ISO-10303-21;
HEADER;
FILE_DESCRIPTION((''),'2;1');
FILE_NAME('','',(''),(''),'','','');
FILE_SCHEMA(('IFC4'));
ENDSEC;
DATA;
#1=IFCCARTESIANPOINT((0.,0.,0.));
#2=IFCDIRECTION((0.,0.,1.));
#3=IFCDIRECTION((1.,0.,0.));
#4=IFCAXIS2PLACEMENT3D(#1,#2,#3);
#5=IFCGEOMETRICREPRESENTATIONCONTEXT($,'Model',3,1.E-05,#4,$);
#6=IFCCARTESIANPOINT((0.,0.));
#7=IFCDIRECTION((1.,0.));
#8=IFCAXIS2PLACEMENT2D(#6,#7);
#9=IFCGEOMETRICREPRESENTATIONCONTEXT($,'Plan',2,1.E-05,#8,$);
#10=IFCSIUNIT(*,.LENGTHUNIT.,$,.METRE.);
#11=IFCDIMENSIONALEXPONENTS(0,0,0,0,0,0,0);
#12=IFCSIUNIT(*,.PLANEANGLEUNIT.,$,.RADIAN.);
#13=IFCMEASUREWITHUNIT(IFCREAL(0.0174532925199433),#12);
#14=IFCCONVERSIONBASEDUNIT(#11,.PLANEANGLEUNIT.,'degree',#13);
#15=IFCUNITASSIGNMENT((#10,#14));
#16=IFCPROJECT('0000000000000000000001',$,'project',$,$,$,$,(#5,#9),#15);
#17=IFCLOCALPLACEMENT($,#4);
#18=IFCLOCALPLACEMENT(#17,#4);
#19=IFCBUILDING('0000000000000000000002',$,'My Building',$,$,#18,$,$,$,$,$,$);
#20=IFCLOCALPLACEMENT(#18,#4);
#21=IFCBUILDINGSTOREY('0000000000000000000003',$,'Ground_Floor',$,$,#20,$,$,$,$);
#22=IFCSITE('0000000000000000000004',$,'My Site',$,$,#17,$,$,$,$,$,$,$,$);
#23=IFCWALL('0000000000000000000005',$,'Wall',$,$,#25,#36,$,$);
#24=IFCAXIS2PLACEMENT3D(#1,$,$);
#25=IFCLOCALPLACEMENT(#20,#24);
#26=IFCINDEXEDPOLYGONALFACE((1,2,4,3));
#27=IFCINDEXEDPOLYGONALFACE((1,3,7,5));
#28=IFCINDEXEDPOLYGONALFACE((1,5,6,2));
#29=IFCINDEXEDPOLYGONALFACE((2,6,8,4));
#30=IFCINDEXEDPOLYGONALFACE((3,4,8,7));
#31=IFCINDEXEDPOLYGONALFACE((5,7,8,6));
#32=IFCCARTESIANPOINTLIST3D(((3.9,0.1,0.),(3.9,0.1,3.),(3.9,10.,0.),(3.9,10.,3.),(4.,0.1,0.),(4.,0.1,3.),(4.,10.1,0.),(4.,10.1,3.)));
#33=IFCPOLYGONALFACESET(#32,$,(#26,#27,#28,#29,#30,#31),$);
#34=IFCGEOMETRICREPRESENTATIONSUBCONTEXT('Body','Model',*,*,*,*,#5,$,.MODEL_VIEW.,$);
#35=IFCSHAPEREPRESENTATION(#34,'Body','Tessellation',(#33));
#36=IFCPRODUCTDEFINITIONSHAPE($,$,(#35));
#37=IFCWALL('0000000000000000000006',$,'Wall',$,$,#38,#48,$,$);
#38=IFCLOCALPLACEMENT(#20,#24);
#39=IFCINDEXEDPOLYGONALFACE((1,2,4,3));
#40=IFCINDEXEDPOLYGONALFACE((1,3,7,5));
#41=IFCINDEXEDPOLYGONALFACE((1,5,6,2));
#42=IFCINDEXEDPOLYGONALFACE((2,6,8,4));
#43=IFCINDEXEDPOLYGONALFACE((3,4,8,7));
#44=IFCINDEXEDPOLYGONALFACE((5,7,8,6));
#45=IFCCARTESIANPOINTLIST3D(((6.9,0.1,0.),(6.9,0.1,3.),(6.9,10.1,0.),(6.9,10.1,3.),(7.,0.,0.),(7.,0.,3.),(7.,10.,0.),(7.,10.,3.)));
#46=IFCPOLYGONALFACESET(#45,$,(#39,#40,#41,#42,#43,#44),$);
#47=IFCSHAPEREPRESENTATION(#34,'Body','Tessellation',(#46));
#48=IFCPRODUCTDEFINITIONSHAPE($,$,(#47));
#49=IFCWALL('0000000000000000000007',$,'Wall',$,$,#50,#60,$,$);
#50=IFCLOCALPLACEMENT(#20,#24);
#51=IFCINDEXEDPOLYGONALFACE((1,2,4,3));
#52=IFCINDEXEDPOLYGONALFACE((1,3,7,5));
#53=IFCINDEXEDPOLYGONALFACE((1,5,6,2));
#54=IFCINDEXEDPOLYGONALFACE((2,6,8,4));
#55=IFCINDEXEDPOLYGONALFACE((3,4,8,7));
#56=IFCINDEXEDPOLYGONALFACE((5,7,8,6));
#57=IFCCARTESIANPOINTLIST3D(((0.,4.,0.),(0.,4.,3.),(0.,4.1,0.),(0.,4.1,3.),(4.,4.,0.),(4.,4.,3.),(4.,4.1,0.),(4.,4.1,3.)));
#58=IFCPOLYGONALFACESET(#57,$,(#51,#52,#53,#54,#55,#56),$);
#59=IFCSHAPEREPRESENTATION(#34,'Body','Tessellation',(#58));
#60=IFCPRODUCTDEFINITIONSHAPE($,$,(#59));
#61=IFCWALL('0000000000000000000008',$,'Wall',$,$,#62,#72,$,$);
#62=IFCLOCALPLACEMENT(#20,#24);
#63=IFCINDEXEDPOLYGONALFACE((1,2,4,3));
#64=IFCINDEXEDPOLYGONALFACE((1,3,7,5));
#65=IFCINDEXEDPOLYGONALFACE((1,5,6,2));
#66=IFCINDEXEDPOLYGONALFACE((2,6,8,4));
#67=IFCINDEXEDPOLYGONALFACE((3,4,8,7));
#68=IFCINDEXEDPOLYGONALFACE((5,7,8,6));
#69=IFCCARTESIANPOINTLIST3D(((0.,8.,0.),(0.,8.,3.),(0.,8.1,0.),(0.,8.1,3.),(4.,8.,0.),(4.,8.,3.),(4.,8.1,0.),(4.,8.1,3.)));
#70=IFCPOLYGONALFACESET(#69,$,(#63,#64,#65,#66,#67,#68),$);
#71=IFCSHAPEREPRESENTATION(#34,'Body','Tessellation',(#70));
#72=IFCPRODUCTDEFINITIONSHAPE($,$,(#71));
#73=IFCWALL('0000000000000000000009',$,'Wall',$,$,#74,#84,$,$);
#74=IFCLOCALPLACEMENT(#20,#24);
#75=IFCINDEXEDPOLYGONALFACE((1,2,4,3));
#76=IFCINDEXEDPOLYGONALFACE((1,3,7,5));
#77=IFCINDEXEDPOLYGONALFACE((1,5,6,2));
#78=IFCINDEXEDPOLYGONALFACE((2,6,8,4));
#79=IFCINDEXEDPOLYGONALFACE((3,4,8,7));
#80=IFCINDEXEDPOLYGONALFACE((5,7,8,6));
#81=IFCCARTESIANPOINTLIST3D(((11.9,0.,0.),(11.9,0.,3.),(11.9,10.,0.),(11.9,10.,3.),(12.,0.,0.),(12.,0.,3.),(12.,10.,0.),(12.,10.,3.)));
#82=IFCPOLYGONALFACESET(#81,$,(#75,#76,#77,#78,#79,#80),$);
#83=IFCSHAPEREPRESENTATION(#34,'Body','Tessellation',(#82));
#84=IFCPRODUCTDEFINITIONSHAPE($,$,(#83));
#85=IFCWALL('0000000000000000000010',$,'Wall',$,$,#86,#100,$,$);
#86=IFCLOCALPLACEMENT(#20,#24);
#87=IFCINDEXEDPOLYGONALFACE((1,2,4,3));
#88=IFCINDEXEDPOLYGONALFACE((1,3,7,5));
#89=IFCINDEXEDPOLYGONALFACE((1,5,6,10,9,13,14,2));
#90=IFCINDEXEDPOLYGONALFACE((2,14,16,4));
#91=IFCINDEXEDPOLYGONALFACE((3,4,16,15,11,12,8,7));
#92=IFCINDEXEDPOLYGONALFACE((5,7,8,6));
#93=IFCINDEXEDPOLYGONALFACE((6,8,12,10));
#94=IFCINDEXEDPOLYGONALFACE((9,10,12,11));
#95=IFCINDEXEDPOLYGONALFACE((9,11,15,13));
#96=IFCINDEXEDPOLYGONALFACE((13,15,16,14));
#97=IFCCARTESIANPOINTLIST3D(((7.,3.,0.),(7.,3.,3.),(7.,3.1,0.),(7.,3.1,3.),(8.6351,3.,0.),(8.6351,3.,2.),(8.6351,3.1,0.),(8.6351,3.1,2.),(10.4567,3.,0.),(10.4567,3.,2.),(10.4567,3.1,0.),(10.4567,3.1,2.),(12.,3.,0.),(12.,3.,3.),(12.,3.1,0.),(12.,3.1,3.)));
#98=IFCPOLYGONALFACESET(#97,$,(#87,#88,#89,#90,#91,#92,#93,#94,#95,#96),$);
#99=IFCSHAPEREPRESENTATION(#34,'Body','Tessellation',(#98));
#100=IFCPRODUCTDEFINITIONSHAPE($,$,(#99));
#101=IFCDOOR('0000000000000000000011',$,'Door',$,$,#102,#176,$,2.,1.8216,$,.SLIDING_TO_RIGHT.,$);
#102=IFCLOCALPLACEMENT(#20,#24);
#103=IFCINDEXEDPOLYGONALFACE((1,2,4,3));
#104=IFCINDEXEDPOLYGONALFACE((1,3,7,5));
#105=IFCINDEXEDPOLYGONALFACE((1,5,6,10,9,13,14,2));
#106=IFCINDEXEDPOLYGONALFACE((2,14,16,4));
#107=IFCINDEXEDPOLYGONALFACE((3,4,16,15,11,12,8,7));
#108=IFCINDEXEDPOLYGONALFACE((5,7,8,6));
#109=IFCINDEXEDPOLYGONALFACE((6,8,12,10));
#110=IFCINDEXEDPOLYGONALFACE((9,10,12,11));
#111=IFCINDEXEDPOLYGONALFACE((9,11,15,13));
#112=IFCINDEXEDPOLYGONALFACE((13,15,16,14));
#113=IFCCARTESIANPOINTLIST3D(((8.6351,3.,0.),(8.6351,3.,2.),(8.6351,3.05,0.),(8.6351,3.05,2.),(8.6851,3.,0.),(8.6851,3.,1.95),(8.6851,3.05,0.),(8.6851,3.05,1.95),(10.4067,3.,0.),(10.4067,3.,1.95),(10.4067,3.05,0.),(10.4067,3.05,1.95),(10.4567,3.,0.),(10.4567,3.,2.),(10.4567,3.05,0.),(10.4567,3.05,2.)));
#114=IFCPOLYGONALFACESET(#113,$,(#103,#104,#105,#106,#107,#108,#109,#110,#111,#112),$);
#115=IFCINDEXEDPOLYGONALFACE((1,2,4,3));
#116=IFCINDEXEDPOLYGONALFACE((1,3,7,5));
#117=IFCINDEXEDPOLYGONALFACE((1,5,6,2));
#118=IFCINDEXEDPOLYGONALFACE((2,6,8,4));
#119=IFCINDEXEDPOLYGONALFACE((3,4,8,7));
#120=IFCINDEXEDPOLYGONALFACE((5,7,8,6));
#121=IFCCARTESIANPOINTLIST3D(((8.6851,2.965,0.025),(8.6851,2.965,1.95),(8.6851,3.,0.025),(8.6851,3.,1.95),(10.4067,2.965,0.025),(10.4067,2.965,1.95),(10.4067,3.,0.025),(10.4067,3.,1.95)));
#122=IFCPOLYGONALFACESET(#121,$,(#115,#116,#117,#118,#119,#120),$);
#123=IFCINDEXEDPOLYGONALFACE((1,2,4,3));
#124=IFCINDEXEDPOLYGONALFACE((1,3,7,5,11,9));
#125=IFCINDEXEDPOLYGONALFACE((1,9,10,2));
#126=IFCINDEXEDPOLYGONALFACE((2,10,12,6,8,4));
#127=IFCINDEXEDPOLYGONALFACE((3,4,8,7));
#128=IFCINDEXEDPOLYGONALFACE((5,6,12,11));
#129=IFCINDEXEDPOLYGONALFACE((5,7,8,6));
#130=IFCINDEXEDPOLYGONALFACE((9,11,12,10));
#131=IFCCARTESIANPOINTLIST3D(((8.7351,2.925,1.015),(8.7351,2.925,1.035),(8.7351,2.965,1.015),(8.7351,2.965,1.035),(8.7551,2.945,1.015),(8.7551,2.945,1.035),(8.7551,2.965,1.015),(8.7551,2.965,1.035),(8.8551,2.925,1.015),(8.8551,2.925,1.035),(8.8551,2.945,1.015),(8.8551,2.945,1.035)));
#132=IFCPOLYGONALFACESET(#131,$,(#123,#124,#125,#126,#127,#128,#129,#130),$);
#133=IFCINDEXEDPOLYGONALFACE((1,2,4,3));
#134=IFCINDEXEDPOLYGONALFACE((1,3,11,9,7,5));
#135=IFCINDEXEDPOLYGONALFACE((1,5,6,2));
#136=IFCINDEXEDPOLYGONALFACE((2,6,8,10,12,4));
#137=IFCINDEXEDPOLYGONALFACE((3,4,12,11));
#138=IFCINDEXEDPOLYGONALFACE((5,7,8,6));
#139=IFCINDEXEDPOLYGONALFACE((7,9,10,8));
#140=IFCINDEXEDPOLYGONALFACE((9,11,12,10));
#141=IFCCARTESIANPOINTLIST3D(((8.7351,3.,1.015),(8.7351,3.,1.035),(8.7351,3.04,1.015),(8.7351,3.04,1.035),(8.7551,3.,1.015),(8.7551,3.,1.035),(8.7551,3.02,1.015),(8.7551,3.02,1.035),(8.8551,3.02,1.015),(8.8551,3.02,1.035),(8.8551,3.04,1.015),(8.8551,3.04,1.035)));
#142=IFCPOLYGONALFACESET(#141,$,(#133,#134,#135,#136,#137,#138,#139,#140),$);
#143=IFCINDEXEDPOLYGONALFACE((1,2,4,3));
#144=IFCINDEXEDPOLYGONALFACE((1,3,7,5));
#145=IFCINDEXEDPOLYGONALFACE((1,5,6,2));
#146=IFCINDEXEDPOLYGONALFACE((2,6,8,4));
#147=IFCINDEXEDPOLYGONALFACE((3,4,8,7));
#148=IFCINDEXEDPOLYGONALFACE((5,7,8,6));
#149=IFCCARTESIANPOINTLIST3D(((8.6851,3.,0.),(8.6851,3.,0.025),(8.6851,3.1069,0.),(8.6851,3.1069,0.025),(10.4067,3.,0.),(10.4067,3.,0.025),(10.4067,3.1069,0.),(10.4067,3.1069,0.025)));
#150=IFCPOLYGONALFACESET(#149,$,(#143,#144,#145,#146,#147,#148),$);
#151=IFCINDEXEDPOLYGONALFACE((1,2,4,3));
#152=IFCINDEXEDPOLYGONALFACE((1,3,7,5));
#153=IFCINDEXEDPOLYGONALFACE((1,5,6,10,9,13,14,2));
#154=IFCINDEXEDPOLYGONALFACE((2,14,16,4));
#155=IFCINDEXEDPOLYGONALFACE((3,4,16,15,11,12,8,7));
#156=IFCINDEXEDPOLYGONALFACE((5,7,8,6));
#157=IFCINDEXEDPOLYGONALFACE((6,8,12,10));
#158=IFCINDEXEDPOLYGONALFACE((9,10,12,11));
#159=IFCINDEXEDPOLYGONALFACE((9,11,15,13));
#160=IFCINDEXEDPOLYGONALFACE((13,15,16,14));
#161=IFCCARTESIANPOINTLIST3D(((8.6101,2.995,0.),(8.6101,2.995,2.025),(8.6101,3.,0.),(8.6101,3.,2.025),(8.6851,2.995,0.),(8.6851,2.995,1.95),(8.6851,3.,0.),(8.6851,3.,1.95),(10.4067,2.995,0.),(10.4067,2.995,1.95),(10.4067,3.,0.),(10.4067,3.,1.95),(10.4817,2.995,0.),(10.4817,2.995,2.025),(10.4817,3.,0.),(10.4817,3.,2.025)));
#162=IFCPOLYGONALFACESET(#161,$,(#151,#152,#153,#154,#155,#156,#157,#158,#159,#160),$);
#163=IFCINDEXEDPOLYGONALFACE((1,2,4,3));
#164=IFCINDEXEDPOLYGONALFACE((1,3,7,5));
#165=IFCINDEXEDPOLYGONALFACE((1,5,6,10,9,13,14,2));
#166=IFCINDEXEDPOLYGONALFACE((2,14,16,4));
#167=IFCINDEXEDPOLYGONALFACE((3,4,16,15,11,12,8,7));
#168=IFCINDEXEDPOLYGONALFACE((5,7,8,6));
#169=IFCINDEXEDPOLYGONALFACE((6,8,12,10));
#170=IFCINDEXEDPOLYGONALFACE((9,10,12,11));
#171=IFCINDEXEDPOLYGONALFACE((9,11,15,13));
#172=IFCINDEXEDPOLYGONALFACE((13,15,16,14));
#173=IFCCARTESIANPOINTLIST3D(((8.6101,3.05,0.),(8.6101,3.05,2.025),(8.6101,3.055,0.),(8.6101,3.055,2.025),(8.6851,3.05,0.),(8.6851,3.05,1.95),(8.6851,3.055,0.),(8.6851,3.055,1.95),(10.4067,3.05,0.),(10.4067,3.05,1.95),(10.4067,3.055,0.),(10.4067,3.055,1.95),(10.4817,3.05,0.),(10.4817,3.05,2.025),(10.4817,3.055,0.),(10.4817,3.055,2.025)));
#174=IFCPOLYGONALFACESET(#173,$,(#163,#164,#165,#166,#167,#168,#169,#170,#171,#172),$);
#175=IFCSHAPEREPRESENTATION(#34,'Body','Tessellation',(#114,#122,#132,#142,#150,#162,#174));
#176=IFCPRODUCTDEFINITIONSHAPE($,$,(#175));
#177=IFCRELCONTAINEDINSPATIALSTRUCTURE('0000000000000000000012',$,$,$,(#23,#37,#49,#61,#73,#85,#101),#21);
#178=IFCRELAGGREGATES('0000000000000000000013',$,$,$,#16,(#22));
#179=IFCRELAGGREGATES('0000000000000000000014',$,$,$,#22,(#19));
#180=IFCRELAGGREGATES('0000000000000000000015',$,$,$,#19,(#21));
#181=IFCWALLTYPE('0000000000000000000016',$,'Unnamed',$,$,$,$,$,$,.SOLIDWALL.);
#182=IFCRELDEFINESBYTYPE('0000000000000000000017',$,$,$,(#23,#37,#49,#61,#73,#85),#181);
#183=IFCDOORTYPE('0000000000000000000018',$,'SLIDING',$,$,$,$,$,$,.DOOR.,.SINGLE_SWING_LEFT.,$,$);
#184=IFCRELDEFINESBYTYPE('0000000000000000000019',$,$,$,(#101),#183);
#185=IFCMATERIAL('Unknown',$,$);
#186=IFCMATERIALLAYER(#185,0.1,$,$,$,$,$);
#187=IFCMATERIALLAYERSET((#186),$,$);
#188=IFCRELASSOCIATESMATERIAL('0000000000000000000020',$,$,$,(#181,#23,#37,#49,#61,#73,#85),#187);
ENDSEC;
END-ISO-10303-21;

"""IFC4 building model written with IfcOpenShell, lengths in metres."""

from ifc_helpers import new_model, entity, si_unit, converted_unit, frame, origin_with_axes, origin_2d_with_axis, place, context, subcontext, project, spatial, line, indexed_curve, outline, extrude, shape, source, transform, mapped, material, layer, layer_set, layer_usage, type_object, type_shapes, element, fill, save


model = new_model("IFC4")

# Units and contexts
model_context = context("Model", 3, precision=1e-05, world=origin_with_axes())
plan_context = context("Plan", 2, precision=1e-05, world=origin_2d_with_axis())
body_context_1 = subcontext(model_context, "Body", "Model", "MODEL_VIEW")
body_context_2 = subcontext(plan_context, "Body", "Plan", "PLAN_VIEW")
ifc_project = project(units=[si_unit("LENGTHUNIT", "METRE"), converted_unit("PLANEANGLEUNIT", "degree", entity("IfcReal", 0.0174532925199433), si_unit("PLANEANGLEUNIT", "RADIAN"), dimensions=[0, 0, 0, 0, 0, 0, 0])], contexts=[model_context, plan_context])

# Site, building, storey
site_placement = place(None, origin_with_axes())
site = spatial("IfcSite", under=ifc_project, at=site_placement, Name="My Site")
building_placement = place(site_placement, origin_with_axes())
building = spatial("IfcBuilding", under=site, at=building_placement, Name="My Building")
storey_placement = place(building_placement, origin_with_axes())
storey = spatial("IfcBuildingStorey", under=building, at=storey_placement, Name="Ground_Floor")

# Walls
ifc_material = material(Name="Unknown")
ifc_layer = layer(ifc_material, 0.1)
ifc_layer_set = layer_set([ifc_layer])
ifc_layer_usage_1 = layer_usage(ifc_layer_set, "AXIS2", "POSITIVE", 0.0)
wall_type = type_object("IfcWallType", Name="Unnamed", PredefinedType="SOLIDWALL", material=ifc_layer_set)
wall_1_placement = place(storey_placement, frame((4.0, 0.0, 0.0), z_axis=(0.0, 0.0, 1.0), x_axis=(0.0, 1.0, 0.0)))
element("IfcWall", 1, at=wall_1_placement, inside=storey, type_object=wall_type, material=ifc_layer_usage_1, Name="Wall", context=body_context_1, shape_type="SweptSolid", body=[
    extrude(outline(indexed_curve([(0.1, 0.0), (0.1, 0.1), (10.0, 0.1), (10.1, 0.0)], segments=[line(1, 2, 3, 4, 1)])), origin_with_axes(), (0.0, 0.0, 1.0), 3.0),
])
ifc_layer_usage_2 = layer_usage(ifc_layer_set, "AXIS2", "POSITIVE", 0.0)
wall_2_placement = place(storey_placement, frame((7.0, 0.0, 0.0), z_axis=(0.0, 0.0, 1.0), x_axis=(0.0, 1.0, 0.0)))
element("IfcWall", 2, at=wall_2_placement, inside=storey, type_object=wall_type, material=ifc_layer_usage_2, Name="Wall", context=body_context_1, shape_type="SweptSolid", body=[
    extrude(outline(indexed_curve([(0.0, 0.0), (0.1, 0.1), (10.1, 0.1), (10.0, 0.0)], segments=[line(1, 2, 3, 4, 1)])), origin_with_axes(), (0.0, 0.0, 1.0), 3.0),
])
ifc_layer_usage_3 = layer_usage(ifc_layer_set, "AXIS2", "POSITIVE", 0.0)
wall_3_placement = place(storey_placement, frame((0.0, 4.0, 0.0), z_axis=(0.0, 0.0, 1.0), x_axis=(1.0, 0.0, 0.0)))
element("IfcWall", 3, at=wall_3_placement, inside=storey, type_object=wall_type, material=ifc_layer_usage_3, Name="Wall", context=body_context_1, shape_type="SweptSolid", body=[
    extrude(outline(indexed_curve([(0.0, 0.0), (0.0, 0.1), (4.0, 0.1), (4.0, 0.0)], segments=[line(1, 2, 3, 4, 1)])), origin_with_axes(), (0.0, 0.0, 1.0), 3.0),
])
ifc_layer_usage_4 = layer_usage(ifc_layer_set, "AXIS2", "POSITIVE", 0.0)
wall_4_placement = place(storey_placement, frame((0.0, 8.0, 0.0), z_axis=(0.0, 0.0, 1.0), x_axis=(1.0, 0.0, 0.0)))
element("IfcWall", 4, at=wall_4_placement, inside=storey, type_object=wall_type, material=ifc_layer_usage_4, Name="Wall", context=body_context_1, shape_type="SweptSolid", body=[
    extrude(outline(indexed_curve([(0.0, 0.0), (0.0, 0.1), (4.0, 0.1), (4.0, 0.0)], segments=[line(1, 2, 3, 4, 1)])), origin_with_axes(), (0.0, 0.0, 1.0), 3.0),
])
ifc_layer_usage_5 = layer_usage(ifc_layer_set, "AXIS2", "POSITIVE", 0.0)
wall_5_placement = place(storey_placement, frame((12.0, 0.0, 0.0), z_axis=(0.0, 0.0, 1.0), x_axis=(0.0, 1.0, 0.0)))
element("IfcWall", 5, at=wall_5_placement, inside=storey, type_object=wall_type, material=ifc_layer_usage_5, Name="Wall", context=body_context_1, shape_type="SweptSolid", body=[
    extrude(outline(indexed_curve([(0.0, 0.0), (0.0, 0.1), (10.0, 0.1), (10.0, 0.0)], segments=[line(1, 2, 3, 4, 1)])), origin_with_axes(), (0.0, 0.0, 1.0), 3.0),
])

# Wall, opening, door
ifc_layer_usage_6 = layer_usage(ifc_layer_set, "AXIS2", "POSITIVE", 0.0)
wall_6_placement = place(storey_placement, frame((7.0, 3.0, 0.0), z_axis=(0.0, 0.0, 1.0), x_axis=(1.0, 0.0, 0.0)))
wall_6 = element("IfcWall", 6, at=wall_6_placement, inside=storey, type_object=wall_type, material=ifc_layer_usage_6, Name="Wall", context=body_context_1, shape_type="SweptSolid", body=[
    extrude(outline(indexed_curve([(0.0, 0.0), (0.0, 0.1), (5.0, 0.1), (5.0, 0.0)], segments=[line(1, 2, 3, 4, 1)])), origin_with_axes(), (0.0, 0.0, 1.0), 3.0),
])
shared_shape_1 = source(origin_with_axes(), body_context_1, "Body", "SweptSolid", [
    extrude(outline(indexed_curve([(0.0, 0.0), (1.8216, 0.0), (1.8216, 2.0), (0.0, 2.0)], segments=[line(1, 2, 3, 4, 1)])), frame((0.0, -0.6, 0.0), z_axis=(0.0, -1.0, 0.0), x_axis=(1.0, 0.0, 0.0)), (0.0, 0.0, -1.0), 1.2),
])
opening_1_placement = place(wall_6_placement, frame((1.6351, 0.0, 0.0), z_axis=(0.0, 0.0, 1.0), x_axis=(1.0, 0.0, 0.0)))
opening_1 = element("IfcOpeningElement", 7, at=opening_1_placement, cuts=wall_6, PredefinedType="OPENING", context=body_context_1, shape_type="MappedRepresentation", body=[
    mapped(shared_shape_1, transform((0.0, 0.0, 0.0), x_axis=(1.0, 0.0, 0.0), y_axis=(0.0, 1.0, 0.0), z_axis=(0.0, 0.0, 1.0), scale=1.0)),
])
door_type_1 = type_object("IfcDoorType", Name="SLIDING", OperationType="SINGLE_SWING_LEFT", PredefinedType="DOOR")
shared_shape_2 = source(origin_with_axes(), body_context_1, "Body", "SweptSolid", [
    extrude(outline(indexed_curve([(0.0, 0.0), (0.0, 2.0), (1.8216, 2.0), (1.8216, 0.0), (1.7716, 0.0), (1.7716, 1.95), (0.05, 1.95), (0.05, 0.0)], segments=[line(1, 2, 3, 4, 5, 6, 7, 8, 1)])), frame((0.0, 0.0, 0.0), z_axis=(0.0, -1.0, 0.0), x_axis=(1.0, 0.0, 0.0)), (0.0, 0.0, -1.0), 0.05),
    extrude(outline(indexed_curve([(0.0, 0.0), (1.7216, 0.0), (1.7216, 0.035), (0.0, 0.035)], segments=[line(1, 2, 3, 4, 1)])), frame((0.05, -0.035, 0.025), z_axis=(0.0, 0.0, 1.0), x_axis=(1.0, 0.0, 0.0)), (0.0, 0.0, 1.0), 1.925),
    extrude(outline(indexed_curve([(0.0, 0.0), (0.0, -0.04), (0.12, -0.04), (0.12, -0.02), (0.02, -0.02), (0.02, 0.0)], segments=[line(1, 2, 3, 4, 5, 6, 1)])), frame((0.1, -0.035, 1.015), z_axis=(0.0, 0.0, 1.0), x_axis=(1.0, 0.0, 0.0)), (0.0, 0.0, 1.0), 0.02),
    extrude(outline(indexed_curve([(0.0, 0.0), (0.0, 0.04), (0.12, 0.04), (0.12, 0.02), (0.02, 0.02), (0.02, 0.0)], segments=[line(1, 2, 3, 4, 5, 6, 1)])), frame((0.1, 0.0, 1.015), z_axis=(0.0, 0.0, 1.0), x_axis=(1.0, 0.0, 0.0)), (0.0, 0.0, 1.0), 0.02),
    extrude(outline(indexed_curve([(0.0, 0.0), (1.7216, 0.0), (1.7216, 0.1069), (0.0, 0.1069)], segments=[line(1, 2, 3, 4, 1)])), frame((0.05, 0.0, 0.0), z_axis=(0.0, 0.0, 1.0), x_axis=(1.0, 0.0, 0.0)), (0.0, 0.0, 1.0), 0.025),
    extrude(outline(indexed_curve([(0.0, 0.0), (0.0, 2.025), (1.8716, 2.025), (1.8716, 0.0), (1.7966, 0.0), (1.7966, 1.95), (0.075, 1.95), (0.075, 0.0)], segments=[line(1, 2, 3, 4, 5, 6, 7, 8, 1)])), frame((-0.025, -0.005, 0.0), z_axis=(0.0, -1.0, 0.0), x_axis=(1.0, 0.0, 0.0)), (0.0, 0.0, -1.0), 0.005),
    extrude(outline(indexed_curve([(0.0, 0.0), (0.0, 2.025), (1.8716, 2.025), (1.8716, 0.0), (1.7966, 0.0), (1.7966, 1.95), (0.075, 1.95), (0.075, 0.0)], segments=[line(1, 2, 3, 4, 5, 6, 7, 8, 1)])), frame((-0.025, 0.05, 0.0), z_axis=(0.0, -1.0, 0.0), x_axis=(1.0, 0.0, 0.0)), (0.0, 0.0, -1.0), 0.005),
])
shared_shape_3 = source(origin_with_axes(), body_context_2, "Body", "Curve2D", [
    entity("IfcIndexedPolyCurve", entity("IfcCartesianPointList2D", [[0.0, 0.0], [0.05, 0.0], [0.05, 0.05], [0.0, 0.05]]), [entity("IfcLineIndex", [1, 2, 3, 4, 1])]),
    entity("IfcIndexedPolyCurve", entity("IfcCartesianPointList2D", [[1.8216, 0.0], [1.7716, 0.0], [1.7716, 0.05], [1.8216, 0.05]]), [entity("IfcLineIndex", [1, 2, 3, 4, 1])]),
    entity("IfcIndexedPolyCurve", entity("IfcCartesianPointList2D", [[2.6325, -0.035], [0.9108, -0.035], [0.9108, 0.0], [2.6325, 0.0]]), [entity("IfcLineIndex", [1, 2, 3, 4, 1])]),
])
type_shapes(door_type_1, [shared_shape_2, shared_shape_3])
door_1_placement = place(opening_1_placement, origin_with_axes())
door_1 = element("IfcDoor", 8, at=door_1_placement, inside=storey, type_object=door_type_1, Name="Door", OperationType="SLIDING_TO_RIGHT", OverallHeight=2.0, OverallWidth=1.8216, shapes=[
    shape(body_context_1, "Body", "MappedRepresentation", [mapped(shared_shape_2, transform((0.0, 0.0, 0.0), x_axis=(1.0, 0.0, 0.0), y_axis=(0.0, 1.0, 0.0), z_axis=(0.0, 0.0, 1.0), scale=1.0))]),
    shape(body_context_2, "Body", "MappedRepresentation", [mapped(shared_shape_3, transform((0.0, 0.0, 0.0), x_axis=(1.0, 0.0, 0.0), y_axis=(0.0, 1.0, 0.0), z_axis=(0.0, 0.0, 1.0), scale=1.0))]),
])
fill(opening_1, door_1)

save(model, "model.ifc")
